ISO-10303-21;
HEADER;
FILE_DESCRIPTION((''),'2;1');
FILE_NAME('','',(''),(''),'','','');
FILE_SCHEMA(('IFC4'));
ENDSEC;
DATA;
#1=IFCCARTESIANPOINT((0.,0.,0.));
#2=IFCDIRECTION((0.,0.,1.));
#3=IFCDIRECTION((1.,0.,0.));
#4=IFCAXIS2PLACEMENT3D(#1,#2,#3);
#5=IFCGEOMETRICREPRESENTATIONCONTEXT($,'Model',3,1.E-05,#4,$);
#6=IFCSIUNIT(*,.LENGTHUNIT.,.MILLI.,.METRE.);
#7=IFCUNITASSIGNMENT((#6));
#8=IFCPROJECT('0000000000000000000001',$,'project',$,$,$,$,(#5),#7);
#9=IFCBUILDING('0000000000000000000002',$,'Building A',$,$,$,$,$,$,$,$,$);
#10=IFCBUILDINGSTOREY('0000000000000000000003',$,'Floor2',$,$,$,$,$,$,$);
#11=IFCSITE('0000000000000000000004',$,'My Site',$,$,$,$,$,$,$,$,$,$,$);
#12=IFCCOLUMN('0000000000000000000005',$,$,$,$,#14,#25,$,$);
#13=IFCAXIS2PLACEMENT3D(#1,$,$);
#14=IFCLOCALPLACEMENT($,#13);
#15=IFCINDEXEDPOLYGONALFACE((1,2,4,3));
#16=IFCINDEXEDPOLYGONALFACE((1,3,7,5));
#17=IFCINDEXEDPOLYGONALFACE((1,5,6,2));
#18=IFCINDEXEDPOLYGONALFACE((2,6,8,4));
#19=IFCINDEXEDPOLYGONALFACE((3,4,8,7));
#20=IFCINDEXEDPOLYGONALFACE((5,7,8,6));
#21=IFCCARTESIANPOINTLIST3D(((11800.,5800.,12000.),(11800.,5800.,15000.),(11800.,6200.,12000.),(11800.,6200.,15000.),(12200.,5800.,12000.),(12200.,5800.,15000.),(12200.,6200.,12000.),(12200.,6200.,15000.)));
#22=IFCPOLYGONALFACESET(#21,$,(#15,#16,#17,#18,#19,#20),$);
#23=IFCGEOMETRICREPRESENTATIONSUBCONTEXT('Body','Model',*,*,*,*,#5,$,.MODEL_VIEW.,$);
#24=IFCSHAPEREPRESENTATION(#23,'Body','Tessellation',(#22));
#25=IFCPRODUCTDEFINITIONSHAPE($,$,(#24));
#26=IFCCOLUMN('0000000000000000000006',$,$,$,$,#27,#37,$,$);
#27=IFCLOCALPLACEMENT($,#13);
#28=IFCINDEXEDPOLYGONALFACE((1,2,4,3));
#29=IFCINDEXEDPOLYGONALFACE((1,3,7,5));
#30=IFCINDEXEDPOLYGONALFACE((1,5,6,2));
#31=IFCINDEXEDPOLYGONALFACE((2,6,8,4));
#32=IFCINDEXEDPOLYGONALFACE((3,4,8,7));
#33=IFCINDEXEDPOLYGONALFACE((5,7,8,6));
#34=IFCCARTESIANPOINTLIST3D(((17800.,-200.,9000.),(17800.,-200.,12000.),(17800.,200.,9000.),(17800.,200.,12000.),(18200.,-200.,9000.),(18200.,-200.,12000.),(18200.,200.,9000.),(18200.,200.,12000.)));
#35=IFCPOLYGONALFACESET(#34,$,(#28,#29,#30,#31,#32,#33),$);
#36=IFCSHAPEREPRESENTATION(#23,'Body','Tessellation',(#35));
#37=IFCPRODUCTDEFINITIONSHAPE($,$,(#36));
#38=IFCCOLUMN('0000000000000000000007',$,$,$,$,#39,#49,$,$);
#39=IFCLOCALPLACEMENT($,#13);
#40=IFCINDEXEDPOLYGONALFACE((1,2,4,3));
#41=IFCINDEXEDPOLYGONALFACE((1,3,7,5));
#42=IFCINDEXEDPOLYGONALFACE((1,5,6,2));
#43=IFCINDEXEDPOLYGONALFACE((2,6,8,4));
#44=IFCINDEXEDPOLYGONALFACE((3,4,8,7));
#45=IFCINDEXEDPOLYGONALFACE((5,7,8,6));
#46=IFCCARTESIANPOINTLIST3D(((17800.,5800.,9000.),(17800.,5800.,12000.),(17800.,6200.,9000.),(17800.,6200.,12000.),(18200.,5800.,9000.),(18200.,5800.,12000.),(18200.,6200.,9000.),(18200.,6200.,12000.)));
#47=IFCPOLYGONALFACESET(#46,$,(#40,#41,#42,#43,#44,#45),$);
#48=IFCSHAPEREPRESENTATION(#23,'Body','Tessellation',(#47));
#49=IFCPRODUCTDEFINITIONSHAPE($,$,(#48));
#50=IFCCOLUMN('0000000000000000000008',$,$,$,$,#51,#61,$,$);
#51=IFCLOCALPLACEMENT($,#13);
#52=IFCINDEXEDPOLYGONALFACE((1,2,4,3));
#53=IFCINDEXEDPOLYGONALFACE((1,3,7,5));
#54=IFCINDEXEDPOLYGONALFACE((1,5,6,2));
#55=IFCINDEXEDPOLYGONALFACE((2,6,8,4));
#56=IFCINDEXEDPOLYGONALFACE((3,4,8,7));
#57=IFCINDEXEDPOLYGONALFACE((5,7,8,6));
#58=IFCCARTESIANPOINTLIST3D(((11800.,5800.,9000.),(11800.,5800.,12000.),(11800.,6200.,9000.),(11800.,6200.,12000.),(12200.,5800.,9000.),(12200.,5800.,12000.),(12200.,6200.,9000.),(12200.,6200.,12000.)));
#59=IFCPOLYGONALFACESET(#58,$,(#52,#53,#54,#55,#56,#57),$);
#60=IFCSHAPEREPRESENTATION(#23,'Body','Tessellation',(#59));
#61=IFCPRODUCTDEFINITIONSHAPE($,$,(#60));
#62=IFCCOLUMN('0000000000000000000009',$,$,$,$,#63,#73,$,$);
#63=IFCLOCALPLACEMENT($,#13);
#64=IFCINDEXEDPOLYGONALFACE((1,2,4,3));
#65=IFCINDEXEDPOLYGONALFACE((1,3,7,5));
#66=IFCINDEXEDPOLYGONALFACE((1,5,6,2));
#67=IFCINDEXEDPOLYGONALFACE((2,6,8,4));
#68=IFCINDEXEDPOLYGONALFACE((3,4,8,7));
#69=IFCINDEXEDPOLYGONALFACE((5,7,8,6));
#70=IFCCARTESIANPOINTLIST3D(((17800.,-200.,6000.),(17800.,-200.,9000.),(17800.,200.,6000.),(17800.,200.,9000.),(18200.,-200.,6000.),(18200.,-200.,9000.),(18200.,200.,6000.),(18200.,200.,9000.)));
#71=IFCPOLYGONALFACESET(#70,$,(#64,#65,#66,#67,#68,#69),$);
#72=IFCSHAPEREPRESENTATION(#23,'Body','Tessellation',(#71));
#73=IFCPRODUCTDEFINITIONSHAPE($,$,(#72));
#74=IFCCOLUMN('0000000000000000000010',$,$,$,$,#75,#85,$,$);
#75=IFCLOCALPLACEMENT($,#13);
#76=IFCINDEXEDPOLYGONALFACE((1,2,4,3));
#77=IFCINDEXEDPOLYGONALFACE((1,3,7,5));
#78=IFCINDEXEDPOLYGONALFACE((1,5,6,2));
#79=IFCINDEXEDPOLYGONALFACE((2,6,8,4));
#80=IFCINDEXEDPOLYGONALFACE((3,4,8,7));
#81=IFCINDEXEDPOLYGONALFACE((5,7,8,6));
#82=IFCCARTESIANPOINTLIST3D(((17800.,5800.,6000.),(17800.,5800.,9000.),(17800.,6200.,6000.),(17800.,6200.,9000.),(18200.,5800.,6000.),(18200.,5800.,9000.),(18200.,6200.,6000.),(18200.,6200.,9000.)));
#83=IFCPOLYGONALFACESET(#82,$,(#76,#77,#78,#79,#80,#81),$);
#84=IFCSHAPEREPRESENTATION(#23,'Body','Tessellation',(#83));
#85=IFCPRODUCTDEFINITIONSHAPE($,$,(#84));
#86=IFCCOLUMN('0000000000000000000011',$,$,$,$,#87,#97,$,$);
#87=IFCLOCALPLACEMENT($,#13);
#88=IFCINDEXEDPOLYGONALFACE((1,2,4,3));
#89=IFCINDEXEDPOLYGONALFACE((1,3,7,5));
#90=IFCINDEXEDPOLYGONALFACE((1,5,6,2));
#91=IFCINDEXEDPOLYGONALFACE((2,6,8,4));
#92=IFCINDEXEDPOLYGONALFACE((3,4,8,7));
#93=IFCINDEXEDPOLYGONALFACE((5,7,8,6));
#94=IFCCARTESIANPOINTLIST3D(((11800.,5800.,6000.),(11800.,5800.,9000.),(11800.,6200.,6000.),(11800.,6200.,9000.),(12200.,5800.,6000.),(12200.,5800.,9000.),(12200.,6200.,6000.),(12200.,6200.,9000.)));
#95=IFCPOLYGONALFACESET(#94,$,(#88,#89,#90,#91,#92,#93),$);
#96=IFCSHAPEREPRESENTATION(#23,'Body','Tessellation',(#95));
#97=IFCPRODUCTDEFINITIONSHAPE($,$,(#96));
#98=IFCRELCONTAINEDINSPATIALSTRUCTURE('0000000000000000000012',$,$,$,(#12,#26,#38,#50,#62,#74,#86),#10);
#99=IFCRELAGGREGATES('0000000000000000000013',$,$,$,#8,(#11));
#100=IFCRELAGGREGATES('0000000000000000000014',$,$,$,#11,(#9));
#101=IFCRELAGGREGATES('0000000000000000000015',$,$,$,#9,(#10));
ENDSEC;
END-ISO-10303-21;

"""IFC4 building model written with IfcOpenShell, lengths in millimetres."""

from ifc_helpers import new_model, si_unit, frame, origin_with_axes, place, context, subcontext, project, spatial, line, indexed_curve, outline, extrude, element, save


model = new_model("IFC4")

# Units and contexts
model_context = context("Model", 3, precision=1e-05, world=origin_with_axes())
body_context = subcontext(model_context, "Body", "Model", "MODEL_VIEW")
ifc_project = project(units=[si_unit("LENGTHUNIT", "METRE", prefix="MILLI")], contexts=[model_context])

# Site, building, storey
site = spatial("IfcSite", under=ifc_project, Name="My Site")
building = spatial("IfcBuilding", under=site, Name="Building A")
storey = spatial("IfcBuildingStorey", under=building, Name="Floor2")

# Columns
for number, where, z_axis, x_axis in (
    (1, (12000.0, 6000.0, 12000.0), (0.0, 0.0, 1.0), (1.0, 0.0, 0.0)),
    (2, (18000.0, 0.0, 9000.0), (0.0, 0.0, 1.0), (1.0, 0.0, 0.0)),
    (3, (18000.0, 6000.0, 9000.0), (0.0, 0.0, 1.0), (1.0, 0.0, 0.0)),
    (4, (12000.0, 6000.0, 9000.0), (0.0, 0.0, 1.0), (1.0, 0.0, 0.0)),
    (5, (18000.0, 0.0, 6000.0), (0.0, 0.0, 1.0), (1.0, 0.0, 0.0)),
    (6, (18000.0, 6000.0, 6000.0), (0.0, 0.0, 1.0), (1.0, 0.0, 0.0)),
    (7, (12000.0, 6000.0, 6000.0), (0.0, 0.0, 1.0), (1.0, 0.0, 0.0)),
):
    element("IfcColumn", number, at=place(None, frame(where, z_axis=z_axis, x_axis=x_axis)), inside=storey, context=body_context, shape_type="SweptSolid", body=[
        extrude(outline(indexed_curve([(-200.0, -200.0), (200.0, -200.0), (200.0, 200.0), (-200.0, 200.0)], segments=[line(1, 2, 3, 4, 1)])), origin_with_axes(), (0.0, 0.0, 1.0), 3000.0),
    ])

save(model, "model.ifc")
